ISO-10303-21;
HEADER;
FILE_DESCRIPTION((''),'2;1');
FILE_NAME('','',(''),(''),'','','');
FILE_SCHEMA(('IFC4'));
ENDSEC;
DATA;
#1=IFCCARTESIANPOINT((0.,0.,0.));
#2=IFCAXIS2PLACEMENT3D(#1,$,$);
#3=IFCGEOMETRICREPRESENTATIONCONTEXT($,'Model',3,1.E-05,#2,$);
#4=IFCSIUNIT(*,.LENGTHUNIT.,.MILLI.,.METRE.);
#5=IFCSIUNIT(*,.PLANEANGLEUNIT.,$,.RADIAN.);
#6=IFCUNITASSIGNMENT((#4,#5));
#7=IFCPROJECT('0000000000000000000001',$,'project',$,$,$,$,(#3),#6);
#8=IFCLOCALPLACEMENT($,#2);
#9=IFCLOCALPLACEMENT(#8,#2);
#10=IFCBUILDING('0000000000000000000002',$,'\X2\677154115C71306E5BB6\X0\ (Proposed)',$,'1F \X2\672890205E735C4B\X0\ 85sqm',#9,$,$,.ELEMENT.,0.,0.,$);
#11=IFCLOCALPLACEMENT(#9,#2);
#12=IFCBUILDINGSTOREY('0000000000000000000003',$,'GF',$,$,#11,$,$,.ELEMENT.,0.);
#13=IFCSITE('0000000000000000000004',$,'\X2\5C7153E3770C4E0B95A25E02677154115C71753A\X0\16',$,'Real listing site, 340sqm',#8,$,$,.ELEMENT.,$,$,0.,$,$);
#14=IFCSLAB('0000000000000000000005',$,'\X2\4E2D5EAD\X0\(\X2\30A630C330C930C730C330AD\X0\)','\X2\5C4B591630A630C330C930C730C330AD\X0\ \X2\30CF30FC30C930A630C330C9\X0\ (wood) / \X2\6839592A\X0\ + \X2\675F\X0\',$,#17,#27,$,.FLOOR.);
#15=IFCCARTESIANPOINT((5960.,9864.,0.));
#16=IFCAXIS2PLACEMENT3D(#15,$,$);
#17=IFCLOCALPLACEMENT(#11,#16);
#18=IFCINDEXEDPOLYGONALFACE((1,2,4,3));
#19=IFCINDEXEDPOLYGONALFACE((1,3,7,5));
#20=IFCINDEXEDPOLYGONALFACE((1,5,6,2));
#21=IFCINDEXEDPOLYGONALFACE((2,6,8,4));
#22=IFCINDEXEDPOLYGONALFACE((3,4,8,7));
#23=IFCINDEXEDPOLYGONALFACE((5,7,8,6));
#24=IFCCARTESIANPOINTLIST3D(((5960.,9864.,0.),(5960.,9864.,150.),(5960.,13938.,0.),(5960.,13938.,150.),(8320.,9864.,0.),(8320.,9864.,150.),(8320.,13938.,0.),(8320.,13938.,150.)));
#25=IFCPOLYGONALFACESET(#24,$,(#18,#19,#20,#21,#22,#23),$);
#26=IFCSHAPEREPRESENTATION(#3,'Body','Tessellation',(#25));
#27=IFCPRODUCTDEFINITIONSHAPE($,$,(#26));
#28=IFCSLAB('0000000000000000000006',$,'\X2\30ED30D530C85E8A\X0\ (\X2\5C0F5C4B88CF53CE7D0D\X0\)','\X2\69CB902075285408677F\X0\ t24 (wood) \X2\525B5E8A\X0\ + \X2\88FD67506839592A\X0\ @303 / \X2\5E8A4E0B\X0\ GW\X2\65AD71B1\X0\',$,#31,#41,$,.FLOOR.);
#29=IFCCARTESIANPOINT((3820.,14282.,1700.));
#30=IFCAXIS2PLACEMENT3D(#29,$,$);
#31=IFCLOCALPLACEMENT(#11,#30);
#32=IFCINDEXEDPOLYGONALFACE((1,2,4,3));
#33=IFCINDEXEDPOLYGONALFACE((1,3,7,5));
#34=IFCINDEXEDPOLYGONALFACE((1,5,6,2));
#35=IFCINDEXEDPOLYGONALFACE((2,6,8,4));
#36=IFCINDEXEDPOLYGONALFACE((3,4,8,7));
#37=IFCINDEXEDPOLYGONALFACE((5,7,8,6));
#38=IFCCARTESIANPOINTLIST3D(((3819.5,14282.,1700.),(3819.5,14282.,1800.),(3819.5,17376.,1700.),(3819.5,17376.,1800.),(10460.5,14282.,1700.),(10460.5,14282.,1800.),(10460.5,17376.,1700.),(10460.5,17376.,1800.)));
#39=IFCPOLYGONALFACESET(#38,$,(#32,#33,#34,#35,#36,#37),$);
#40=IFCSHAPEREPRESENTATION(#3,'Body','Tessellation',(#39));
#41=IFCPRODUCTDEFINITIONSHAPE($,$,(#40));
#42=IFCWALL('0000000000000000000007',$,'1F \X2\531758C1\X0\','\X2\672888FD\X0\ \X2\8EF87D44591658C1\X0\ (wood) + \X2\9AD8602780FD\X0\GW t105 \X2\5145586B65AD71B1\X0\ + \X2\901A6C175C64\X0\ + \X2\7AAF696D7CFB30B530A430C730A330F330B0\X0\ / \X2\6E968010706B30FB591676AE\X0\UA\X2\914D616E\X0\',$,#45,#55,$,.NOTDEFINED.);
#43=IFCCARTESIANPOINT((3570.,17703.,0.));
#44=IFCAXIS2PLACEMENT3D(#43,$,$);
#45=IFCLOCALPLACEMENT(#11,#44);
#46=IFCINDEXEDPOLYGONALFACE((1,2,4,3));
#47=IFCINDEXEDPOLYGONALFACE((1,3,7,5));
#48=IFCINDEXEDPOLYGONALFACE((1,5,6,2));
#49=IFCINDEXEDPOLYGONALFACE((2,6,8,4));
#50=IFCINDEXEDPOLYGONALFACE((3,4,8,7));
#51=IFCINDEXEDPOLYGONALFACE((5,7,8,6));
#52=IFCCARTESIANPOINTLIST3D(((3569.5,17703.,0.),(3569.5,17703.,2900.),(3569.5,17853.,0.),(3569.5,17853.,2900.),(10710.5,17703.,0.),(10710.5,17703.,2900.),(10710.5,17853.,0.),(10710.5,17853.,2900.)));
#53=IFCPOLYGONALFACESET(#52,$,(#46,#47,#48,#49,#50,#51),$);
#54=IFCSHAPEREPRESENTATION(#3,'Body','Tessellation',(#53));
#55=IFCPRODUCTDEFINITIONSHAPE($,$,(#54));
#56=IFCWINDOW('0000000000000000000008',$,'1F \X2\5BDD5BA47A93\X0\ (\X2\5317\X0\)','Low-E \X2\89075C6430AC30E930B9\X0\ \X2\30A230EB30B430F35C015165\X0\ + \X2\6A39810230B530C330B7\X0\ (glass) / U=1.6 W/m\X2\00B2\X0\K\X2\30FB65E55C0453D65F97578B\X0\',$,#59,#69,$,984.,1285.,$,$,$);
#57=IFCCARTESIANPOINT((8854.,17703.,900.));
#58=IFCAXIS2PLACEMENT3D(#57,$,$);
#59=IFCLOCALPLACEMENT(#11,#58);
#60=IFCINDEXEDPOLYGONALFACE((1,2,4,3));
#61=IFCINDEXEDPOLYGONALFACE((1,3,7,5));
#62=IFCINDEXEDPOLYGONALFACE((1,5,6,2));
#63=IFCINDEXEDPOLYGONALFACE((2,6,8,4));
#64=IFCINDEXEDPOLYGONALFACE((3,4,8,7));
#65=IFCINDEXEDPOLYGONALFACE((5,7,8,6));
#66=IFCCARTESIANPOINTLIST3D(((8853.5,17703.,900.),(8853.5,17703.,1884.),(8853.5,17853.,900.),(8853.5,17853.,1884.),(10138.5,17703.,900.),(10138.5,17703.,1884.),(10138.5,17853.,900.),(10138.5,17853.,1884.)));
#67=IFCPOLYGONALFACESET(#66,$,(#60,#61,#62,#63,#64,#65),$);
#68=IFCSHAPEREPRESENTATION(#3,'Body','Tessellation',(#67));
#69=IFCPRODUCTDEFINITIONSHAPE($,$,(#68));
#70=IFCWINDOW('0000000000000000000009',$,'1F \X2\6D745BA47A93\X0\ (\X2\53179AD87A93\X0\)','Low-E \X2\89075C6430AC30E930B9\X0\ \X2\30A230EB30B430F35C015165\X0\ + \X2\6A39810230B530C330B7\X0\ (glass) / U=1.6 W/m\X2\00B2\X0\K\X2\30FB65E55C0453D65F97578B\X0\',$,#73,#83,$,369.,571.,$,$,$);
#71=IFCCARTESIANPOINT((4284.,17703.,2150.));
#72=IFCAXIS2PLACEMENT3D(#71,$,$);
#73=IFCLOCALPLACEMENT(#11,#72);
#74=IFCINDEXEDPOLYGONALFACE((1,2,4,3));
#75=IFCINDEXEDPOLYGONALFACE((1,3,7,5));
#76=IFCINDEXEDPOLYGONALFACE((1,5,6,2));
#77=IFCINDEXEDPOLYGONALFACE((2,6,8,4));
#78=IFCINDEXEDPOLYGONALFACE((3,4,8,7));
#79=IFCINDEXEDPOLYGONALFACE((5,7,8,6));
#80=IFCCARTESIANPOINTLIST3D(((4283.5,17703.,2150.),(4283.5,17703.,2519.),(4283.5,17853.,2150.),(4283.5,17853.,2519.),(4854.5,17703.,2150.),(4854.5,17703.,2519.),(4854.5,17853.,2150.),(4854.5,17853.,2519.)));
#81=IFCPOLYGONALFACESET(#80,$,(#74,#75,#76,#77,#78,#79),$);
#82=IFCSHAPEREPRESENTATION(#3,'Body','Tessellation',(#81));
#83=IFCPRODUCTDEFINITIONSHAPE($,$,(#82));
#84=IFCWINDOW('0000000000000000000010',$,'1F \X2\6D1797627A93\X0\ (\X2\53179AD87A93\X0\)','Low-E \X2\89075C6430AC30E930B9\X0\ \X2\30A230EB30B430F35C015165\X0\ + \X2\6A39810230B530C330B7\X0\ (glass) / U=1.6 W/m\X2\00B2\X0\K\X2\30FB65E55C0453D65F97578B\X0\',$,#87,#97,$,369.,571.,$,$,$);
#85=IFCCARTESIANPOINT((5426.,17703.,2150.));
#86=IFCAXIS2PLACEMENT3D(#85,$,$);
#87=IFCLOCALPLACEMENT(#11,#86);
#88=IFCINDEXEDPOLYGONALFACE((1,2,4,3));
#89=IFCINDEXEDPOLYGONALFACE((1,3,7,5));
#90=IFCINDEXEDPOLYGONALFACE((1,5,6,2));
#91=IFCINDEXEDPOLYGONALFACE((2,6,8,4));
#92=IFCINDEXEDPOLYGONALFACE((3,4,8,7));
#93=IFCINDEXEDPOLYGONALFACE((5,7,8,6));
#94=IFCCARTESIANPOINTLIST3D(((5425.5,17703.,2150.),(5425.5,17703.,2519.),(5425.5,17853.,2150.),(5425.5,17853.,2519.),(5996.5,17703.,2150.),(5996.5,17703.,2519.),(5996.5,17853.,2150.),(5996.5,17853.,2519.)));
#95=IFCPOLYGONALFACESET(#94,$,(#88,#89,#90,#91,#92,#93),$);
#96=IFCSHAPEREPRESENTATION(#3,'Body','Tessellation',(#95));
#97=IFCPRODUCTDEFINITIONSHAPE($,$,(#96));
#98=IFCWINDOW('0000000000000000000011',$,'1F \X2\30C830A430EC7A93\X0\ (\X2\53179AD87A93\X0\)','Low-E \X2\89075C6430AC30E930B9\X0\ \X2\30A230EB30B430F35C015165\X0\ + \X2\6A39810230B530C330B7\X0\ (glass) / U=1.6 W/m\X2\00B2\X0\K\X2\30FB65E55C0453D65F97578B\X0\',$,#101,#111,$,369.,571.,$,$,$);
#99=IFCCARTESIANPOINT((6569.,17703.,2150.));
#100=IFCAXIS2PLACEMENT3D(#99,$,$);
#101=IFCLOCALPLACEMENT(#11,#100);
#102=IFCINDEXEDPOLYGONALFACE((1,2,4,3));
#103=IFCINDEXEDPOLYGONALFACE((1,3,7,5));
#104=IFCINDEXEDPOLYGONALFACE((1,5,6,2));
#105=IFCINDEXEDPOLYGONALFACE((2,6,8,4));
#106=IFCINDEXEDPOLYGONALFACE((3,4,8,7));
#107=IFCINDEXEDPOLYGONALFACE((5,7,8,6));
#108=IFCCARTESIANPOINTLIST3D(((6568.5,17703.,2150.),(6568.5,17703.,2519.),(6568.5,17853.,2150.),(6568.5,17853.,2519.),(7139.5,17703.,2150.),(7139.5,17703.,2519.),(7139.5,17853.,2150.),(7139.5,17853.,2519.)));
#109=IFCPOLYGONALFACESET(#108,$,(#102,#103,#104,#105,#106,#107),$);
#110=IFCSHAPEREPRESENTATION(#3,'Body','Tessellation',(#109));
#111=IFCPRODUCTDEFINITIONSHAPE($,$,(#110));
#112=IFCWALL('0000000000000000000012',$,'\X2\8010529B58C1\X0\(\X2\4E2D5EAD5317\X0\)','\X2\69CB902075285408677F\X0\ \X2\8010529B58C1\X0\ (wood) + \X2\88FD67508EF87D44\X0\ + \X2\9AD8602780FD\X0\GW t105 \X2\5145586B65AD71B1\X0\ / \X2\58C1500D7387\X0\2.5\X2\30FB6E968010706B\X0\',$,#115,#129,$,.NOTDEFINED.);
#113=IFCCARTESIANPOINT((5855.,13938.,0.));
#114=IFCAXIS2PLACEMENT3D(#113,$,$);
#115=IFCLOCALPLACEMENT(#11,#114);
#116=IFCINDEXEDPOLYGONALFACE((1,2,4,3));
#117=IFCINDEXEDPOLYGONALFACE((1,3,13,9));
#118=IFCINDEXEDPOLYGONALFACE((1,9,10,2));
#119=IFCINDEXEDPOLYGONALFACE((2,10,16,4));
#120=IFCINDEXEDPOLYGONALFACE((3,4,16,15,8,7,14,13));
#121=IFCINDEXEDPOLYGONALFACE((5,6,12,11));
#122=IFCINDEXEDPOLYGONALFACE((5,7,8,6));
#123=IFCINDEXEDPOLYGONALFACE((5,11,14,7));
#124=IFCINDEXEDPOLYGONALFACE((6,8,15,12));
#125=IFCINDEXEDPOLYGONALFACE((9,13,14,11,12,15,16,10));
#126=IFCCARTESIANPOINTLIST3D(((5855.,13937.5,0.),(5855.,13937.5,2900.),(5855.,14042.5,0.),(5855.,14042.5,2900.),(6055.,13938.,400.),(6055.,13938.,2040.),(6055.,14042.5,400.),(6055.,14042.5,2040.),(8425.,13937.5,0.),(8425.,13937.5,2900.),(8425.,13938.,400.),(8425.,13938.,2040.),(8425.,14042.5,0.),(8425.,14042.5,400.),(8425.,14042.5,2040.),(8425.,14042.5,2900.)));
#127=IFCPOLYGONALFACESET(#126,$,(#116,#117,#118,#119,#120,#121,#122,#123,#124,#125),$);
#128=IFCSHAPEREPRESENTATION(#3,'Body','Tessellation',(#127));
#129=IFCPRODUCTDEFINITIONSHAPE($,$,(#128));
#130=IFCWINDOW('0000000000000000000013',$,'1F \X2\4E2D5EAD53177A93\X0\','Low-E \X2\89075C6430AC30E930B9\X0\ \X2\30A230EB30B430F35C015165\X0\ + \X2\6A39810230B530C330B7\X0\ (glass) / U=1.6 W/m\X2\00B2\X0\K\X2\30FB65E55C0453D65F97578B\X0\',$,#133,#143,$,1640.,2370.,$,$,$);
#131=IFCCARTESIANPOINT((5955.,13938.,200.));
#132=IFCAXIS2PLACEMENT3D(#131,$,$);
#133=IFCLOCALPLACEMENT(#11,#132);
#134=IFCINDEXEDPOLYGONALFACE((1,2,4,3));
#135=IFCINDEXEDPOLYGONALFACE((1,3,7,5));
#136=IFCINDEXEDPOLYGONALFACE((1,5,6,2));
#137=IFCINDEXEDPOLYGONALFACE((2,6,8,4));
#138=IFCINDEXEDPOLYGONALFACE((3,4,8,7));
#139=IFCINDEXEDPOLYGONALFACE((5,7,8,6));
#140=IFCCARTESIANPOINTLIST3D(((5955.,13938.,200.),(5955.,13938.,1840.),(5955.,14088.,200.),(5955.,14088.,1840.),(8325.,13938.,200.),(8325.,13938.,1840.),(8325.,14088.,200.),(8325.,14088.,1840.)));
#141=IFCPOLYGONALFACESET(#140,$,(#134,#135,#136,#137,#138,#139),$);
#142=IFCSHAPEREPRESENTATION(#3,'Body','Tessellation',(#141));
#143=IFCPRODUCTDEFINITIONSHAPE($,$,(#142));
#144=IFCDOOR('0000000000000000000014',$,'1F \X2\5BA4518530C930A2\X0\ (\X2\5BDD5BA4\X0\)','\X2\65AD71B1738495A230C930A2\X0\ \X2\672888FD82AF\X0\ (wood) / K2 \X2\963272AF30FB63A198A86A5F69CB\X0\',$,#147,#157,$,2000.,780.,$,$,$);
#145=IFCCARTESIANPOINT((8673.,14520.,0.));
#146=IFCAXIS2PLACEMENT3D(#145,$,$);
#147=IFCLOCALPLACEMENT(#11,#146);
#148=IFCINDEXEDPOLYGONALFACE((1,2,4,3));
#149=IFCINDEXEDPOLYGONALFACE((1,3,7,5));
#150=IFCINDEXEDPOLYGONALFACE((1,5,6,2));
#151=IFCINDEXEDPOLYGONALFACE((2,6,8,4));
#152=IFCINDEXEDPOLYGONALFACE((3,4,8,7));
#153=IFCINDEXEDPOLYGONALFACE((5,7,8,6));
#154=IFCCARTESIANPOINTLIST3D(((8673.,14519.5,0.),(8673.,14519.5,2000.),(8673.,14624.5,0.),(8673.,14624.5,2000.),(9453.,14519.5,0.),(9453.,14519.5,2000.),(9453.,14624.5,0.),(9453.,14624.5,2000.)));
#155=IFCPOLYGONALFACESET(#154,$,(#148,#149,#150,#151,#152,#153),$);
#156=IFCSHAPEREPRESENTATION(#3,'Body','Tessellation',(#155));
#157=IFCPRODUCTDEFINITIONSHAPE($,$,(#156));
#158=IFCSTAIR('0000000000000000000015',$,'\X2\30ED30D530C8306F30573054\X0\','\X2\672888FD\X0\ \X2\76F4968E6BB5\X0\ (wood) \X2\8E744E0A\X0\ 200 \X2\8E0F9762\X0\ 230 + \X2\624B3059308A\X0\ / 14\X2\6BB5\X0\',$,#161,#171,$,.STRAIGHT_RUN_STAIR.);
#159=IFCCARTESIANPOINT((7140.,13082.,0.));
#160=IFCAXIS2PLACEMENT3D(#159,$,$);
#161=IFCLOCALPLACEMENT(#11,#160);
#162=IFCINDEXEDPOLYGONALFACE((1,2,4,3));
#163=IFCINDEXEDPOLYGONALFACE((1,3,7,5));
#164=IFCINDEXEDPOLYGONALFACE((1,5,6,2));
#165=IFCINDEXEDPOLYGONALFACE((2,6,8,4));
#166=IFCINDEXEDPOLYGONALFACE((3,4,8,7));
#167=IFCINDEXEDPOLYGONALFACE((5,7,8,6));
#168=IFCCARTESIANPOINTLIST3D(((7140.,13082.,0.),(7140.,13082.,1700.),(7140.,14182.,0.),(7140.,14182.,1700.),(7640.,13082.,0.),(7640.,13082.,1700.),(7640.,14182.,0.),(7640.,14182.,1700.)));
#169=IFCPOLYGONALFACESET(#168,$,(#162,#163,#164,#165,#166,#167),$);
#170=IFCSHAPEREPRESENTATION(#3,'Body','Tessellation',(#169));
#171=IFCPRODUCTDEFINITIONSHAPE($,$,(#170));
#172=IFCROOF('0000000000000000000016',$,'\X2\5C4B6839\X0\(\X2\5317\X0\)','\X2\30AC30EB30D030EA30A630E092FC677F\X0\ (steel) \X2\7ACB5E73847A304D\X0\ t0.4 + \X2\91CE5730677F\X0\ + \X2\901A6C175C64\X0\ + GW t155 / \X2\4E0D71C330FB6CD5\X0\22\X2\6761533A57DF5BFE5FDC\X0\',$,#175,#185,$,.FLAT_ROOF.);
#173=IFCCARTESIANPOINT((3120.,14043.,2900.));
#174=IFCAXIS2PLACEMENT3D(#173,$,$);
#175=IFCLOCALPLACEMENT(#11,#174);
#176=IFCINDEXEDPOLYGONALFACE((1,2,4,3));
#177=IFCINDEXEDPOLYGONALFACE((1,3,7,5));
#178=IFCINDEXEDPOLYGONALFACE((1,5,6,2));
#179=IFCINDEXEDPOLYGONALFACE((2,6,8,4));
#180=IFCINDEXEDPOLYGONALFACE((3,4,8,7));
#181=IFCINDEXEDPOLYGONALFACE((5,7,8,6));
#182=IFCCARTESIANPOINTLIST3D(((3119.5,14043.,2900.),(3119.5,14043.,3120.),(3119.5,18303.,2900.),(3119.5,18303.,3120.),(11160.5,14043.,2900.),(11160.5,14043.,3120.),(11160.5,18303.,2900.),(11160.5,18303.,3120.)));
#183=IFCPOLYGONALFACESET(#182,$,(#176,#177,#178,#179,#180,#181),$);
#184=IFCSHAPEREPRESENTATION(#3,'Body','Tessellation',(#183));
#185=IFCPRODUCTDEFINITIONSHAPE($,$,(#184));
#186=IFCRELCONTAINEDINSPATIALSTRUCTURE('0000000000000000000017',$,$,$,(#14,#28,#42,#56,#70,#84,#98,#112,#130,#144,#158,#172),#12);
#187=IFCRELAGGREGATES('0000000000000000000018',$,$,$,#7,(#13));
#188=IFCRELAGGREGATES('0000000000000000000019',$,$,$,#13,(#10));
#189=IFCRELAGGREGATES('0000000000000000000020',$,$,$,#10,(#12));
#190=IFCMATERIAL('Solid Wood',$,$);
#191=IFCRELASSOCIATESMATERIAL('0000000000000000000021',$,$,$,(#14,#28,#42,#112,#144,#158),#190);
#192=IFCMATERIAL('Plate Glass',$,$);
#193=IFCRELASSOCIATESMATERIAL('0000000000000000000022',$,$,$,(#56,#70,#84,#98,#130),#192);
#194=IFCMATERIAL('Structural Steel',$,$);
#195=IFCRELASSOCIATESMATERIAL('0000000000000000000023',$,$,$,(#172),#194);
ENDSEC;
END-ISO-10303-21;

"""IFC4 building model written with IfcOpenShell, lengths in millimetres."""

from ifc_helpers import new_model, si_unit, frame, frame_2d, origin, place, context, project, spatial, rectangle, extrude, material, element, fill, save


model = new_model("IFC4")

# Units and contexts
model_context = context("Model", 3, precision=1e-05, world=origin())
ifc_project = project(units=[si_unit("LENGTHUNIT", "METRE", prefix="MILLI"), si_unit("PLANEANGLEUNIT", "RADIAN")], contexts=[model_context])

# Site, building, storey
site_placement = place(None, origin())
site = spatial("IfcSite", under=ifc_project, at=site_placement, Name="山口県下関市東向山町16", ObjectType="Real listing site, 340sqm", CompositionType="ELEMENT", RefElevation=0.0)
building_placement = place(site_placement, origin())
building = spatial("IfcBuilding", under=site, at=building_placement, Name="東向山の家 (Proposed)", ObjectType="1F 木造平屋 85sqm", CompositionType="ELEMENT", ElevationOfRefHeight=0.0, ElevationOfTerrain=0.0)
storey_placement = place(building_placement, origin())
storey = spatial("IfcBuildingStorey", under=building, at=storey_placement, Name="GF", CompositionType="ELEMENT", Elevation=0.0)

# Slabs
ifc_material_1 = material(Name="Solid Wood")
slab_1_placement = place(storey_placement, frame((5960.0, 9864.0, 0.0)))
element("IfcSlab", 1, at=slab_1_placement, inside=storey, material=ifc_material_1, Name="中庭(ウッドデッキ)", Description="屋外ウッドデッキ ハードウッド (wood) / 根太 + 束", PredefinedType="FLOOR", context=model_context, shape_type="SweptSolid", body=[
    extrude(rectangle(XDim=2360.0, YDim=4074.0, at=frame_2d((1180.0, 2037.0))), frame((5960.0, 9864.0, 0.0)), (0.0, 0.0, 1.0), 150.0),
])
slab_2_placement = place(storey_placement, frame((3820.0, 14282.0, 1700.0)))
element("IfcSlab", 2, at=slab_2_placement, inside=storey, material=ifc_material_1, Name="ロフト床 (小屋裏収納)", Description="構造用合板 t24 (wood) 剛床 + 製材根太 @303 / 床下 GW断熱", PredefinedType="FLOOR", context=model_context, shape_type="SweptSolid", body=[
    extrude(rectangle(XDim=6641.0, YDim=3094.0, at=frame_2d((3320.0, 1547.0))), frame((3820.0, 14282.0, 1700.0)), (0.0, 0.0, 1.0), 100.0),
])

# Wall, openings, windows
wall_1_placement = place(storey_placement, frame((3570.0, 17703.0, 0.0)))
wall_1 = element("IfcWall", 3, at=wall_1_placement, inside=storey, material=ifc_material_1, Name="1F 北壁", Description="木製 軸組外壁 (wood) + 高性能GW t105 充填断熱 + 通気層 + 窯業系サイディング / 準耐火・外皮UA配慮", PredefinedType="NOTDEFINED", context=model_context, shape_type="SweptSolid", body=[
    extrude(rectangle(XDim=7141.0, YDim=150.0, at=frame_2d((3570.0, 75.0))), frame((3570.0, 17703.0, 0.0)), (0.0, 0.0, 1.0), 2900.0),
])
opening_1_placement = place(storey_placement, frame((8854.0, 17703.0, 900.0)))
opening_1 = element("IfcOpeningElement", 4, at=opening_1_placement, cuts=wall_1, PredefinedType="NOTDEFINED", context=model_context, shape_type="SweptSolid", body=[
    extrude(rectangle(XDim=1285.0, YDim=150.0, at=frame_2d((642.0, 75.0))), frame((8854.0, 17703.0, 900.0)), (0.0, 0.0, 1.0), 984.0),
])
opening_2_placement = place(storey_placement, frame((4284.0, 17703.0, 2150.0)))
opening_2 = element("IfcOpeningElement", 5, at=opening_2_placement, cuts=wall_1, PredefinedType="NOTDEFINED", context=model_context, shape_type="SweptSolid", body=[
    extrude(rectangle(XDim=571.0, YDim=150.0, at=frame_2d((285.0, 75.0))), frame((4284.0, 17703.0, 2150.0)), (0.0, 0.0, 1.0), 369.0),
])
opening_3_placement = place(storey_placement, frame((5426.0, 17703.0, 2150.0)))
opening_3 = element("IfcOpeningElement", 6, at=opening_3_placement, cuts=wall_1, PredefinedType="NOTDEFINED", context=model_context, shape_type="SweptSolid", body=[
    extrude(rectangle(XDim=571.0, YDim=150.0, at=frame_2d((285.0, 75.0))), frame((5426.0, 17703.0, 2150.0)), (0.0, 0.0, 1.0), 369.0),
])
opening_4_placement = place(storey_placement, frame((6569.0, 17703.0, 2150.0)))
opening_4 = element("IfcOpeningElement", 7, at=opening_4_placement, cuts=wall_1, PredefinedType="NOTDEFINED", context=model_context, shape_type="SweptSolid", body=[
    extrude(rectangle(XDim=571.0, YDim=150.0, at=frame_2d((285.0, 75.0))), frame((6569.0, 17703.0, 2150.0)), (0.0, 0.0, 1.0), 369.0),
])
ifc_material_2 = material(Name="Plate Glass")
window_1_placement = place(storey_placement, frame((8854.0, 17703.0, 900.0)))
window_1 = element("IfcWindow", 8, at=window_1_placement, inside=storey, material=ifc_material_2, Name="1F 寝室窓 (北)", Description="Low-E 複層ガラス アルゴン封入 + 樹脂サッシ (glass) / U=1.6 W/m²K・日射取得型", OverallHeight=984.0, OverallWidth=1285.0, context=model_context, shape_type="SweptSolid", body=[
    extrude(rectangle(XDim=1285.0, YDim=150.0, at=frame_2d((642.0, 75.0))), frame((8854.0, 17703.0, 900.0)), (0.0, 0.0, 1.0), 984.0),
])
fill(opening_1, window_1)
window_2_placement = place(storey_placement, frame((4284.0, 17703.0, 2150.0)))
window_2 = element("IfcWindow", 9, at=window_2_placement, inside=storey, material=ifc_material_2, Name="1F 浴室窓 (北高窓)", Description="Low-E 複層ガラス アルゴン封入 + 樹脂サッシ (glass) / U=1.6 W/m²K・日射取得型", OverallHeight=369.0, OverallWidth=571.0, context=model_context, shape_type="SweptSolid", body=[
    extrude(rectangle(XDim=571.0, YDim=150.0, at=frame_2d((285.0, 75.0))), frame((4284.0, 17703.0, 2150.0)), (0.0, 0.0, 1.0), 369.0),
])
fill(opening_2, window_2)
window_3_placement = place(storey_placement, frame((5426.0, 17703.0, 2150.0)))
window_3 = element("IfcWindow", 10, at=window_3_placement, inside=storey, material=ifc_material_2, Name="1F 洗面窓 (北高窓)", Description="Low-E 複層ガラス アルゴン封入 + 樹脂サッシ (glass) / U=1.6 W/m²K・日射取得型", OverallHeight=369.0, OverallWidth=571.0, context=model_context, shape_type="SweptSolid", body=[
    extrude(rectangle(XDim=571.0, YDim=150.0, at=frame_2d((285.0, 75.0))), frame((5426.0, 17703.0, 2150.0)), (0.0, 0.0, 1.0), 369.0),
])
fill(opening_3, window_3)
window_4_placement = place(storey_placement, frame((6569.0, 17703.0, 2150.0)))
window_4 = element("IfcWindow", 11, at=window_4_placement, inside=storey, material=ifc_material_2, Name="1F トイレ窓 (北高窓)", Description="Low-E 複層ガラス アルゴン封入 + 樹脂サッシ (glass) / U=1.6 W/m²K・日射取得型", OverallHeight=369.0, OverallWidth=571.0, context=model_context, shape_type="SweptSolid", body=[
    extrude(rectangle(XDim=571.0, YDim=150.0, at=frame_2d((285.0, 75.0))), frame((6569.0, 17703.0, 2150.0)), (0.0, 0.0, 1.0), 369.0),
])
fill(opening_4, window_4)

# Wall, opening, window
wall_2_placement = place(storey_placement, frame((5855.0, 13938.0, 0.0)))
wall_2 = element("IfcWall", 12, at=wall_2_placement, inside=storey, material=ifc_material_1, Name="耐力壁(中庭北)", Description="構造用合板 耐力壁 (wood) + 製材軸組 + 高性能GW t105 充填断熱 / 壁倍率2.5・準耐火", PredefinedType="NOTDEFINED", context=model_context, shape_type="SweptSolid", body=[
    extrude(rectangle(XDim=2570.0, YDim=105.0, at=frame_2d((1285.0, 52.0))), frame((5855.0, 13938.0, 0.0)), (0.0, 0.0, 1.0), 2900.0),
])
opening_5_placement = place(storey_placement, frame((5955.0, 13938.0, 200.0)))
opening_5 = element("IfcOpeningElement", 13, at=opening_5_placement, cuts=wall_2, PredefinedType="NOTDEFINED", context=model_context, shape_type="SweptSolid", body=[
    extrude(rectangle(XDim=2370.0, YDim=150.0, at=frame_2d((1185.0, 75.0))), frame((5955.0, 13938.0, 200.0)), (0.0, 0.0, 1.0), 1640.0),
])
window_5_placement = place(storey_placement, frame((5955.0, 13938.0, 200.0)))
window_5 = element("IfcWindow", 14, at=window_5_placement, inside=storey, material=ifc_material_2, Name="1F 中庭北窓", Description="Low-E 複層ガラス アルゴン封入 + 樹脂サッシ (glass) / U=1.6 W/m²K・日射取得型", OverallHeight=1640.0, OverallWidth=2370.0, context=model_context, shape_type="SweptSolid", body=[
    extrude(rectangle(XDim=2370.0, YDim=150.0, at=frame_2d((1185.0, 75.0))), frame((5955.0, 13938.0, 200.0)), (0.0, 0.0, 1.0), 1640.0),
])
fill(opening_5, window_5)

# Door
door_1_placement = place(storey_placement, frame((8673.0, 14520.0, 0.0)))
element("IfcDoor", 15, at=door_1_placement, inside=storey, material=ifc_material_1, Name="1F 室内ドア (寝室)", Description="断熱玄関ドア 木製芯 (wood) / K2 防犯・採風機構", OverallHeight=2000.0, OverallWidth=780.0, context=model_context, shape_type="SweptSolid", body=[
    extrude(rectangle(XDim=780.0, YDim=105.0, at=frame_2d((390.0, 52.0))), frame((8673.0, 14520.0, 0.0)), (0.0, 0.0, 1.0), 2000.0),
])

# Stair
stair_placement = place(storey_placement, frame((7140.0, 13082.0, 0.0)))
element("IfcStair", 16, at=stair_placement, inside=storey, material=ifc_material_1, Name="ロフトはしご", Description="木製 直階段 (wood) 蹴上 200 踏面 230 + 手すり / 14段", PredefinedType="STRAIGHT_RUN_STAIR", context=model_context, shape_type="SweptSolid", body=[
    extrude(rectangle(XDim=500.0, YDim=1100.0, at=frame_2d((250.0, 550.0))), frame((7140.0, 13082.0, 0.0)), (0.0, 0.0, 1.0), 1700.0),
])

# Roof
ifc_material_3 = material(Name="Structural Steel")
roof_1_placement = place(storey_placement, frame((3120.0, 14043.0, 2900.0)))
element("IfcRoof", 17, at=roof_1_placement, inside=storey, material=ifc_material_3, Name="屋根(北)", Description="ガルバリウム鋼板 (steel) 立平葺き t0.4 + 野地板 + 通気層 + GW t155 / 不燃・法22条区域対応", PredefinedType="FLAT_ROOF", context=model_context, shape_type="SweptSolid", body=[
    extrude(rectangle(XDim=8041.0, YDim=4260.0, at=frame_2d((4020.0, 2130.0))), frame((3120.0, 14043.0, 2900.0)), (0.0, 0.0, 1.0), 220.0),
])

save(model, "model.ifc")
